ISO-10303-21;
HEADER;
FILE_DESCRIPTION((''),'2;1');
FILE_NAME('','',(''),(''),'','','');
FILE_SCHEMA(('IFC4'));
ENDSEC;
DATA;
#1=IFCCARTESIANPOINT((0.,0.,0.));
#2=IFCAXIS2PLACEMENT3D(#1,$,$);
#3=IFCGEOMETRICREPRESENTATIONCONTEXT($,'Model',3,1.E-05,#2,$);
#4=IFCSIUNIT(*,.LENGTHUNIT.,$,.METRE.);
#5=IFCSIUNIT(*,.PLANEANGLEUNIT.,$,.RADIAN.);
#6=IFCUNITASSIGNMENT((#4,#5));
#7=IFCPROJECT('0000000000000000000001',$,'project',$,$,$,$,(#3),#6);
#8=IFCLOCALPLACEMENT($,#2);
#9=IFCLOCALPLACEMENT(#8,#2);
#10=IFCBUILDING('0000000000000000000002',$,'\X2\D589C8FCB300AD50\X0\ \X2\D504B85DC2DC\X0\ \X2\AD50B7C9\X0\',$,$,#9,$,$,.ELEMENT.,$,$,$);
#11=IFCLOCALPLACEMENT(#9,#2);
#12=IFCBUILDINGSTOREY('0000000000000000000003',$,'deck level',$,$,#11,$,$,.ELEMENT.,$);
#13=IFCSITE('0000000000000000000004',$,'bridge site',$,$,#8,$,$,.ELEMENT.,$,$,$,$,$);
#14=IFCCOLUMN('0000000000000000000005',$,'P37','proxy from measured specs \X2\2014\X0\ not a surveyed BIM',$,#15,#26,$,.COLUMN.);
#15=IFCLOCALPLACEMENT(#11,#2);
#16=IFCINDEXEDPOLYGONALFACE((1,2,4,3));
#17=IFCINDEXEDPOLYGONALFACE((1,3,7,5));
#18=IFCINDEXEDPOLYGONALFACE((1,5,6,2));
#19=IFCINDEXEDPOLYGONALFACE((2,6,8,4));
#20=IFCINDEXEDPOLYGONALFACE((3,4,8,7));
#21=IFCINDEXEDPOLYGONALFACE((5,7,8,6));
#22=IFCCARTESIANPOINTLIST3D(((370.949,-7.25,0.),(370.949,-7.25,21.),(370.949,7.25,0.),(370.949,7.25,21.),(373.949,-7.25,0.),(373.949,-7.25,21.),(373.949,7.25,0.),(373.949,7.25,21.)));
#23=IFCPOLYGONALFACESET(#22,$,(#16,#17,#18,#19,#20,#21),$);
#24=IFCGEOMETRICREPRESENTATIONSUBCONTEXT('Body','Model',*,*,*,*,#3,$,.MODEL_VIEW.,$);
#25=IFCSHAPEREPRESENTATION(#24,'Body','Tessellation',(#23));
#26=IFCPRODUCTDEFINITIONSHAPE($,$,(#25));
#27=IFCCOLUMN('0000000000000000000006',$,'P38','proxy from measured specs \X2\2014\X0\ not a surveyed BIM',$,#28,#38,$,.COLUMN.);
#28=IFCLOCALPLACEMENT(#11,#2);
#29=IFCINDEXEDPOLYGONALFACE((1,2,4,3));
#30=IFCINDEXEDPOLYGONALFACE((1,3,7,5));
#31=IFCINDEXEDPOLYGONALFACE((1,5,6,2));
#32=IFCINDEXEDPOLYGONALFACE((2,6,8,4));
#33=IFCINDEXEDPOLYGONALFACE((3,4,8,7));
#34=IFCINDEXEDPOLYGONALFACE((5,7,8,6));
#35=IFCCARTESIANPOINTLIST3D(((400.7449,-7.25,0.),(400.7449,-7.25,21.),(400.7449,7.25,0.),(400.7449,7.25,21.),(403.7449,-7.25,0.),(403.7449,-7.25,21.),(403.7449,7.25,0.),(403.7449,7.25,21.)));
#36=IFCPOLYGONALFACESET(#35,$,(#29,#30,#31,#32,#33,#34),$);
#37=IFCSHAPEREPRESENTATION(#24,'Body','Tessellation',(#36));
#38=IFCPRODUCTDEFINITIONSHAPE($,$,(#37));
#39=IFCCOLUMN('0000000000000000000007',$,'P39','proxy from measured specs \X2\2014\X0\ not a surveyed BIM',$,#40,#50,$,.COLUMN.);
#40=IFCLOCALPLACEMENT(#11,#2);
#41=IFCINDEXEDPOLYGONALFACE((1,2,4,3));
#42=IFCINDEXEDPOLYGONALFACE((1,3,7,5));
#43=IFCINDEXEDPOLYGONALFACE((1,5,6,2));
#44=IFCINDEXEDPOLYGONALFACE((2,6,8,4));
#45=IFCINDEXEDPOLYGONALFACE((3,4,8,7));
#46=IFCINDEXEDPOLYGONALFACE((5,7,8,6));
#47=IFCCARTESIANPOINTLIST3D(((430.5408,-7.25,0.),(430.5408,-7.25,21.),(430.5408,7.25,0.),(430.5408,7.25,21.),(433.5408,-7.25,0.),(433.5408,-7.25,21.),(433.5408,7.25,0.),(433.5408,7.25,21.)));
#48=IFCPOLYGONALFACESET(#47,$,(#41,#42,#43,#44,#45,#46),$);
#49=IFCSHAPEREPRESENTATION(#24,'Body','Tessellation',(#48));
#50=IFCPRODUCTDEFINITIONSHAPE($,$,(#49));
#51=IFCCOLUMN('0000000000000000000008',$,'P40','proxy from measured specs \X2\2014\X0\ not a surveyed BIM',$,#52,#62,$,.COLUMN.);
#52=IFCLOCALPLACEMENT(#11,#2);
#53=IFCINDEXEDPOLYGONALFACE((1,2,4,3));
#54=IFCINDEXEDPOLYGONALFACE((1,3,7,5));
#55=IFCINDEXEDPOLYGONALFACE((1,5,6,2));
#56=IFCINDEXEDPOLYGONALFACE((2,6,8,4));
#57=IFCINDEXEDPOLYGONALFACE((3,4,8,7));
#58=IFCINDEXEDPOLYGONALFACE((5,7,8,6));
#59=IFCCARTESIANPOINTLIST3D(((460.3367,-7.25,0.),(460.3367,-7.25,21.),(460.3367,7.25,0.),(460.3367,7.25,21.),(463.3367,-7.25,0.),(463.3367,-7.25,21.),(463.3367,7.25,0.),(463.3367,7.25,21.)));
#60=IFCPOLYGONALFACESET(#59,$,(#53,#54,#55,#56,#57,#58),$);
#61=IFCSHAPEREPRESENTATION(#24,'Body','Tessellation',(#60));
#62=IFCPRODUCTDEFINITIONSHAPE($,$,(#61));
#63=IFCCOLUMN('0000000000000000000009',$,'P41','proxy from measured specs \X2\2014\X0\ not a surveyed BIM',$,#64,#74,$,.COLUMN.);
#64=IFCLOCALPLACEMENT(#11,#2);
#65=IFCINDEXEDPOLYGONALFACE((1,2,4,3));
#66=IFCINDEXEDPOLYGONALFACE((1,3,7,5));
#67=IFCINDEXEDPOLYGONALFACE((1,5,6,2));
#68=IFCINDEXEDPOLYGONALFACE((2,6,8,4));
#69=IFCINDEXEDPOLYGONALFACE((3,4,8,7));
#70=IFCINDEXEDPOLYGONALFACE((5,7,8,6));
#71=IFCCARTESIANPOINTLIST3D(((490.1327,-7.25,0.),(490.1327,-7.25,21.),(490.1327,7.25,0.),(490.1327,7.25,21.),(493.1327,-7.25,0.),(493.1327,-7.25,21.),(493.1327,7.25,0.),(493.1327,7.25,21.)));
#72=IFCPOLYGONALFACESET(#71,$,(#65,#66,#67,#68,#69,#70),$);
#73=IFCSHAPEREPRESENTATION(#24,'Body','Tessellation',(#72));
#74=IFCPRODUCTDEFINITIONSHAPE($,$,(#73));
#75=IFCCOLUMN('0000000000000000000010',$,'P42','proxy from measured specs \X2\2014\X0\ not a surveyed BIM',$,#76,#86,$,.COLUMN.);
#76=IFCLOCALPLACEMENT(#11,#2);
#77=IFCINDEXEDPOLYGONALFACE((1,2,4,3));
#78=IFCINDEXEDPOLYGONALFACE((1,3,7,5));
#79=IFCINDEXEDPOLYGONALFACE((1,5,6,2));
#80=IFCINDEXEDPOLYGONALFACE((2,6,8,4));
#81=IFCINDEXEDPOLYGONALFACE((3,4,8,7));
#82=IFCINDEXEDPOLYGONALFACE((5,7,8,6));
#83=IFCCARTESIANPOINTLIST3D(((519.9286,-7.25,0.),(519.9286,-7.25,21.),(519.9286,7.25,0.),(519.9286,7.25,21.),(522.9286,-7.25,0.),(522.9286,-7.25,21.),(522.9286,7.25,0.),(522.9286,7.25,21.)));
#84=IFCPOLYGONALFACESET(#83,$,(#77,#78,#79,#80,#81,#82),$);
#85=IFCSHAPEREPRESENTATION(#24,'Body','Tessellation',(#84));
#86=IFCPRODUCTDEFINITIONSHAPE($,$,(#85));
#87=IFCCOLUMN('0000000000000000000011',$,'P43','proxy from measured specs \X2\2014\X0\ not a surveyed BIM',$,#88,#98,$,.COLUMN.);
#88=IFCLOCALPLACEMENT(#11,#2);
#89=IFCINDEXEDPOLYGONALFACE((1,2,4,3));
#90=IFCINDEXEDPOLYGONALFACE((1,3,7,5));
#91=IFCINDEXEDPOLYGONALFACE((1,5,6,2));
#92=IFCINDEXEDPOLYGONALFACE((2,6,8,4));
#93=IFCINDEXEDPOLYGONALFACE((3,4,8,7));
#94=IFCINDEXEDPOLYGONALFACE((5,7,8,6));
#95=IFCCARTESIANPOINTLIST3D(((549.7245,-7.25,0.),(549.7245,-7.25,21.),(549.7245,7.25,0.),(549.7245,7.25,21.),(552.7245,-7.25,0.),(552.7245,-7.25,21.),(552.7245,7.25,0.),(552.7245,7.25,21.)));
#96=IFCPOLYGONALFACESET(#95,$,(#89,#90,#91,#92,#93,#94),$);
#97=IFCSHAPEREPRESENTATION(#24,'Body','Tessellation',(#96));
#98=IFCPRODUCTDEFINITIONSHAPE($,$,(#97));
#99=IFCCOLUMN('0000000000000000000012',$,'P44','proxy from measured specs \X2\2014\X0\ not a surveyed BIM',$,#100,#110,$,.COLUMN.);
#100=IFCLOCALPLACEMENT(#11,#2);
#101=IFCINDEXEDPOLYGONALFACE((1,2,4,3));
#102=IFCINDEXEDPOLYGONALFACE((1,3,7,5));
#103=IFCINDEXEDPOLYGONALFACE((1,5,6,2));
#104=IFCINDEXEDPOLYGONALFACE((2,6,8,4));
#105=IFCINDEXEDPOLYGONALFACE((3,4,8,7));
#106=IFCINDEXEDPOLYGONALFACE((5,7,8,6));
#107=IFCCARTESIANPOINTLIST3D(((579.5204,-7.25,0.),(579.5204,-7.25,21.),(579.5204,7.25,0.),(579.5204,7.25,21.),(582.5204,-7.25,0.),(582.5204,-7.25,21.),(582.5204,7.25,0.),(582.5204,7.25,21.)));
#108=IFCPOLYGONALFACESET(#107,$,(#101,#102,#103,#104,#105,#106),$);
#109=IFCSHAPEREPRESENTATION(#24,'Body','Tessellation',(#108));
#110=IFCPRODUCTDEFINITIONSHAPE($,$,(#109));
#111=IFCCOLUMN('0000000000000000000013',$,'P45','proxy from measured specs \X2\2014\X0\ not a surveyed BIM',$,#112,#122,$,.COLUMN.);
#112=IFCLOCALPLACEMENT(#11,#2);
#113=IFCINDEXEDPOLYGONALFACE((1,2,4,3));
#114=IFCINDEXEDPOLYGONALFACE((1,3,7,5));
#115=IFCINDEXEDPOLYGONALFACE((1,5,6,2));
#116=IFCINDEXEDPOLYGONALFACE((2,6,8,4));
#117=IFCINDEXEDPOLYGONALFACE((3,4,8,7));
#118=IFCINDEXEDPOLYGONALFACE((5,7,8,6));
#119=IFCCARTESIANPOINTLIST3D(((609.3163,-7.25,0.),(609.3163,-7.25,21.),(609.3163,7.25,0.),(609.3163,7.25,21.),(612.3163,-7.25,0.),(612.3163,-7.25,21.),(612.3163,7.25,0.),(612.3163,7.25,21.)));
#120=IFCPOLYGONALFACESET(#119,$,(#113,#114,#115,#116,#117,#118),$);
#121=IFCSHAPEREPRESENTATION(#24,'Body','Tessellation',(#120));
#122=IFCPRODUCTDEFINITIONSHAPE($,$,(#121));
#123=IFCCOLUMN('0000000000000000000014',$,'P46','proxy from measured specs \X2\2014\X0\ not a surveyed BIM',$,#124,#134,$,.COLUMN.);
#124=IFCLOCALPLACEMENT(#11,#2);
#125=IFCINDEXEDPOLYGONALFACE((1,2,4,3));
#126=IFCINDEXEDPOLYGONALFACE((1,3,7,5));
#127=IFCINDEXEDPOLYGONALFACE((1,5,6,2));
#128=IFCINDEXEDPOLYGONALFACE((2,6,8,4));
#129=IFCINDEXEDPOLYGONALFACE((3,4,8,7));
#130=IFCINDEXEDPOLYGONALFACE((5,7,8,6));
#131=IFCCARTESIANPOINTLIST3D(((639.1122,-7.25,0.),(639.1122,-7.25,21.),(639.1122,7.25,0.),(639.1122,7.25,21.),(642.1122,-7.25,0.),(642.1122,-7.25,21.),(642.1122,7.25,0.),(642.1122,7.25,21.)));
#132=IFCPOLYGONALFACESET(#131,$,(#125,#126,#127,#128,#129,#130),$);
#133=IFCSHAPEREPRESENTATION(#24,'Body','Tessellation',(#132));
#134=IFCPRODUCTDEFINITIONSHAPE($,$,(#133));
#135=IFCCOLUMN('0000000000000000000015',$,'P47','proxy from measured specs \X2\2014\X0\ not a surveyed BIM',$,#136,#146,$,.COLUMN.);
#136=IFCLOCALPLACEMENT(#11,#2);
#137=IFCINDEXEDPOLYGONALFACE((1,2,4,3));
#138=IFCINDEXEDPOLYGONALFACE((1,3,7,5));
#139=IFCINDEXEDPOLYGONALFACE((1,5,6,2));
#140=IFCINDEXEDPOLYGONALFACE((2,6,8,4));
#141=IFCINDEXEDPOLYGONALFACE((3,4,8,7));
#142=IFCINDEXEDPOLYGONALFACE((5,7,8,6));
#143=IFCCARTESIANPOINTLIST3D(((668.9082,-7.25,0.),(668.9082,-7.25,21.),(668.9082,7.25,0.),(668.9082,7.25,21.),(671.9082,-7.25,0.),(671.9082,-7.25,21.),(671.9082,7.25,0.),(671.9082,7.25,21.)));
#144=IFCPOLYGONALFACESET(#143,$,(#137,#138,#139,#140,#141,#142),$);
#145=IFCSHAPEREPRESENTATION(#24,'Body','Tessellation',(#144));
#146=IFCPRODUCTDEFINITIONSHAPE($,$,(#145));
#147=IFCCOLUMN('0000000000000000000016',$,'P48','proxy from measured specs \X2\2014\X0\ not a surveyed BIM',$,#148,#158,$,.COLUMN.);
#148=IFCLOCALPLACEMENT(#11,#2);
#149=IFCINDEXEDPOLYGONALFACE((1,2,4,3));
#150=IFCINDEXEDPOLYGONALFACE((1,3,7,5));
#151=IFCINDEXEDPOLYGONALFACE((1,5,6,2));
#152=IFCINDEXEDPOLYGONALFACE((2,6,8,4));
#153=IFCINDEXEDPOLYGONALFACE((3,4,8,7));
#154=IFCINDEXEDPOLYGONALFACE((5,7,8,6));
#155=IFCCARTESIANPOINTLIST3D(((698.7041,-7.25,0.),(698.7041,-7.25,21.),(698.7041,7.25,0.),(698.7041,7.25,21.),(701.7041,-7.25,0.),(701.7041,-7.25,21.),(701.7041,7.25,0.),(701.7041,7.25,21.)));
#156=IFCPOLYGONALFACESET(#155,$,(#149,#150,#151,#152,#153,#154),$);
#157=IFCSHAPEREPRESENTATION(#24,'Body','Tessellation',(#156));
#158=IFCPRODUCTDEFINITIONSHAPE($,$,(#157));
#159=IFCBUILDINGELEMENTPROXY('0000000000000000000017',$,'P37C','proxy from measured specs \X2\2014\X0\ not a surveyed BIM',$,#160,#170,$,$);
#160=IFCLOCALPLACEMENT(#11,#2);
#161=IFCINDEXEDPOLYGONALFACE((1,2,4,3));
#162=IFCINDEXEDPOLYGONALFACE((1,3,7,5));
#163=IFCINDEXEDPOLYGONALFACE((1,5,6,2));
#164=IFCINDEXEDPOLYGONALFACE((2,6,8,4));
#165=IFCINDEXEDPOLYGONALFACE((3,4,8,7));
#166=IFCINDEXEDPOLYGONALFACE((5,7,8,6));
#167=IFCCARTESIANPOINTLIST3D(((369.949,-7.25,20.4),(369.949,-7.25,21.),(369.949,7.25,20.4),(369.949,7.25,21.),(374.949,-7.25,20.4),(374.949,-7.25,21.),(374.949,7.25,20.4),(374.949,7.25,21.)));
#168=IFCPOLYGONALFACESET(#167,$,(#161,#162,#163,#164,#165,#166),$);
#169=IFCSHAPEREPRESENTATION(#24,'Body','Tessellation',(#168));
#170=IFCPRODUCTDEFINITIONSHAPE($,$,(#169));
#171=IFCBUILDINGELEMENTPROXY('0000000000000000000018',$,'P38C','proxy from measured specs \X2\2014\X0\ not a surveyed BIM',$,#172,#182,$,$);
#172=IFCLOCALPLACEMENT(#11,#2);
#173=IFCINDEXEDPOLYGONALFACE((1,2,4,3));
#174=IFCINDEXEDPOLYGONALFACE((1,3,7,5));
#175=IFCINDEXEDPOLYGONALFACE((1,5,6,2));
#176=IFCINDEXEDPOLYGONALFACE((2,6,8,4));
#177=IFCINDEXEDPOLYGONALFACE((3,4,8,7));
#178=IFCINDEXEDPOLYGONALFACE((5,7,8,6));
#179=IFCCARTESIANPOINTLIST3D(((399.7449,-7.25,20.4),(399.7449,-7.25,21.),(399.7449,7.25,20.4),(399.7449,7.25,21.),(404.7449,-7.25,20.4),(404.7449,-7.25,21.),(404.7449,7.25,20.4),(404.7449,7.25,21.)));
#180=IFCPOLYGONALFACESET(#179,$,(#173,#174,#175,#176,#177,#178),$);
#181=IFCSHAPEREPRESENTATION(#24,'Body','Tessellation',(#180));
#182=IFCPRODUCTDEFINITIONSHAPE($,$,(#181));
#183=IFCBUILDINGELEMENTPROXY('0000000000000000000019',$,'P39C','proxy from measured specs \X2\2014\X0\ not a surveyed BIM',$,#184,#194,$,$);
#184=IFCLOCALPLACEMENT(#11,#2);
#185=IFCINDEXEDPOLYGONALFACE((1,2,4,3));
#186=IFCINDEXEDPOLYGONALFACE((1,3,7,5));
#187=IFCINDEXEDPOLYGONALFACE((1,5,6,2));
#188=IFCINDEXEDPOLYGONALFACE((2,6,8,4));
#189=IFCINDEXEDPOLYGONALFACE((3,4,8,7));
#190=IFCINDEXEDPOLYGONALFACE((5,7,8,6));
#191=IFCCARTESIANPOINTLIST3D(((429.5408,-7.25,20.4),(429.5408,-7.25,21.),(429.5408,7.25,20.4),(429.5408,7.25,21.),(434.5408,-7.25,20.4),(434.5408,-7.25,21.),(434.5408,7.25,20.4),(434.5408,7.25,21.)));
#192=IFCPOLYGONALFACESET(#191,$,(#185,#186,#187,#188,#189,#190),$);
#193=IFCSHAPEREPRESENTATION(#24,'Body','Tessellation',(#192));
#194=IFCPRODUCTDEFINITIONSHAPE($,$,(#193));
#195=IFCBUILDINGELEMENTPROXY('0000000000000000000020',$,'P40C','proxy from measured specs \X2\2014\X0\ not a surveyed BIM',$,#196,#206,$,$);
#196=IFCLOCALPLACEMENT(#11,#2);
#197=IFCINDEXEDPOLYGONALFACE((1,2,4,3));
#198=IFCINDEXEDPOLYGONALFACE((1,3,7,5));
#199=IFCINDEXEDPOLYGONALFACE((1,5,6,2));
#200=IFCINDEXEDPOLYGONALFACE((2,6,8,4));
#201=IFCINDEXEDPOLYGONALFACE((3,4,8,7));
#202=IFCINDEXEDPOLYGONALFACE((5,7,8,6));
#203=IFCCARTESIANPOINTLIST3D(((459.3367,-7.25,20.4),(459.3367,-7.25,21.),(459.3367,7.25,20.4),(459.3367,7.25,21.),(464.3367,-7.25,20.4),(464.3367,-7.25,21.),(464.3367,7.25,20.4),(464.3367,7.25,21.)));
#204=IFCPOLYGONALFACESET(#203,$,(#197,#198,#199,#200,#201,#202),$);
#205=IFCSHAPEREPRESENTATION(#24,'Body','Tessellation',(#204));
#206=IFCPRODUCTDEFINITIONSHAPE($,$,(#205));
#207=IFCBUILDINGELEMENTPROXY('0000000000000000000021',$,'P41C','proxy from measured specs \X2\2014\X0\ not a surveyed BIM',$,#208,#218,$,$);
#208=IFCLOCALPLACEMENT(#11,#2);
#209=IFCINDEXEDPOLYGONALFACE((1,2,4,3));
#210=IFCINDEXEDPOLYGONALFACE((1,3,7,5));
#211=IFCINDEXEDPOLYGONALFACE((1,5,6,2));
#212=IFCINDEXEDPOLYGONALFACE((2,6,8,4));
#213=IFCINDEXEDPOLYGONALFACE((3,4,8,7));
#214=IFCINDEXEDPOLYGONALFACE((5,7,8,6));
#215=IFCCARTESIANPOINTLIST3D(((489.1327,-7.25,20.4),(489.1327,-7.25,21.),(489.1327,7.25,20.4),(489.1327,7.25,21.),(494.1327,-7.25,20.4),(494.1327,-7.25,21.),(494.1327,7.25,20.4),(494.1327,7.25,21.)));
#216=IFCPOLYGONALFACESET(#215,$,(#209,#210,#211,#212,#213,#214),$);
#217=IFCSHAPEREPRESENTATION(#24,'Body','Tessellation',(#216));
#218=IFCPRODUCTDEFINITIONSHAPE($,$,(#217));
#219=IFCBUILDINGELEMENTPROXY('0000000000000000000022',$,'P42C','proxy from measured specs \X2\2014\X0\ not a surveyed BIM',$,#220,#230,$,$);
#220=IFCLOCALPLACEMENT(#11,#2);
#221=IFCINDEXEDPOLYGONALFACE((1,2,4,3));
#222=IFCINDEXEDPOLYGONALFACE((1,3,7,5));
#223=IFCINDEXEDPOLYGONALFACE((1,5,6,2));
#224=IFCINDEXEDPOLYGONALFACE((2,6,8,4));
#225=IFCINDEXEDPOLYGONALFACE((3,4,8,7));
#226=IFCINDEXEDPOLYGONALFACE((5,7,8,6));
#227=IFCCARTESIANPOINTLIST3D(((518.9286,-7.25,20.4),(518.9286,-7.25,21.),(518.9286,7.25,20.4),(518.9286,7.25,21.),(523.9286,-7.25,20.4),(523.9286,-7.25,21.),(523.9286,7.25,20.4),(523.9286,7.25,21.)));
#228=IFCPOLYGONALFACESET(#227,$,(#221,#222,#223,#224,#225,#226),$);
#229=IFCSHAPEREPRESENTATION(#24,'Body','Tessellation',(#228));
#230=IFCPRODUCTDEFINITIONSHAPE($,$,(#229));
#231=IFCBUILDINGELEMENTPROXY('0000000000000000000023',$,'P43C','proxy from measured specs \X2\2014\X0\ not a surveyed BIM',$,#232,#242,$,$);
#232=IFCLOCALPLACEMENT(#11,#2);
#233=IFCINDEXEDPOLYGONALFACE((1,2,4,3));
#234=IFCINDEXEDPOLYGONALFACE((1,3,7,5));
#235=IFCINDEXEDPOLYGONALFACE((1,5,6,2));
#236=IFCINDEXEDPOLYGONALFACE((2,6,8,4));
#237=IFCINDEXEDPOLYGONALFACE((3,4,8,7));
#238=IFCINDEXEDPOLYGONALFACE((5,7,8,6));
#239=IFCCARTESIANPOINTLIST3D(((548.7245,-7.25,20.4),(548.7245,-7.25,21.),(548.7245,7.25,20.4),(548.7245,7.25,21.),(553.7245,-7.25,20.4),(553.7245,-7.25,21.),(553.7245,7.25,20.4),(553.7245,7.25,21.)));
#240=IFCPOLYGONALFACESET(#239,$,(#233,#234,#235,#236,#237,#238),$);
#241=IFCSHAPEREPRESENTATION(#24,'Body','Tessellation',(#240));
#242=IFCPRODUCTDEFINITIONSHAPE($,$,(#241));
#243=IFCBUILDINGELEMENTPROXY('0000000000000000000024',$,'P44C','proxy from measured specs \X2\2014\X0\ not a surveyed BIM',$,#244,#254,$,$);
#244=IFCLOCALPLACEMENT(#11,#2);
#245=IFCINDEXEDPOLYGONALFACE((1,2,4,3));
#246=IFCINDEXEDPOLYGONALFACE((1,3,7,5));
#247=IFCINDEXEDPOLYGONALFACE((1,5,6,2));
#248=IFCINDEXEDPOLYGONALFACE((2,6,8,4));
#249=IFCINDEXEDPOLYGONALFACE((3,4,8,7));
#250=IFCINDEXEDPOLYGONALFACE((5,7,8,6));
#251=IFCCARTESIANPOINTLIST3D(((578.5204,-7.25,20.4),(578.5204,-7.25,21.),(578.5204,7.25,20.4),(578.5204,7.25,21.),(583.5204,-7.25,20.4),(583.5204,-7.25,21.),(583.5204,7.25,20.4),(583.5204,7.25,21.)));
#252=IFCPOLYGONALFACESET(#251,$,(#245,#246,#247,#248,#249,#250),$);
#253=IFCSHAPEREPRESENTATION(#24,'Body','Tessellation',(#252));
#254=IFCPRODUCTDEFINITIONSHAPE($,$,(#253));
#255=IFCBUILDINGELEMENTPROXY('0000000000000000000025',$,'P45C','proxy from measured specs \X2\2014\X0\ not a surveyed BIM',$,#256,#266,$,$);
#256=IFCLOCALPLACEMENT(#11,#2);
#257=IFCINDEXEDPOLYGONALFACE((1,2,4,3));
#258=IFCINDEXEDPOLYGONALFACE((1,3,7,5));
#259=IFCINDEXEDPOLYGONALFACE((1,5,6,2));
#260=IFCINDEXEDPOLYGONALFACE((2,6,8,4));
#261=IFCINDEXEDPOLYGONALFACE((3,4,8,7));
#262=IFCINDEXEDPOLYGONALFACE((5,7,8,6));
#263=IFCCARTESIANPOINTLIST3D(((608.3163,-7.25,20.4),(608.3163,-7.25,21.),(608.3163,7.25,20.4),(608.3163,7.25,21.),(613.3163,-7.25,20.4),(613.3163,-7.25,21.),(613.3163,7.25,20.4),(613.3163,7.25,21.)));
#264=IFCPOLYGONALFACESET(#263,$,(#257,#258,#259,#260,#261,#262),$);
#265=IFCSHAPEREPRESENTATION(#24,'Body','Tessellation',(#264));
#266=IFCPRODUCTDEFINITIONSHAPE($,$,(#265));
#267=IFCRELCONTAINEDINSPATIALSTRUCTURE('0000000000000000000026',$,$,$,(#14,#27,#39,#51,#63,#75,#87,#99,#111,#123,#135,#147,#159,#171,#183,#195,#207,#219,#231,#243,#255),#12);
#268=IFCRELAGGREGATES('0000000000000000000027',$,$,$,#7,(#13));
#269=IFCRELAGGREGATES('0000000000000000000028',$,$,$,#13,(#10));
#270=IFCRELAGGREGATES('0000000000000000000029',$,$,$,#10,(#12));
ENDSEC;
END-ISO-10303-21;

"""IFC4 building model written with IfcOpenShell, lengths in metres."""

from ifc_helpers import new_model, si_unit, frame, origin, origin_2d, place, context, subcontext, project, spatial, rectangle, extrude, element, save


model = new_model("IFC4")

# Units and contexts
model_context = context("Model", 3, precision=1e-05, world=origin())
body_context = subcontext(model_context, "Body", "Model", "MODEL_VIEW")
ifc_project = project(units=[si_unit("LENGTHUNIT", "METRE"), si_unit("PLANEANGLEUNIT", "RADIAN")], contexts=[model_context])

# Site, building, storey
site_placement = place(None, origin())
site = spatial("IfcSite", under=ifc_project, at=site_placement, Name="bridge site", CompositionType="ELEMENT")
building_placement = place(site_placement, origin())
building = spatial("IfcBuilding", under=site, at=building_placement, Name="행주대교 프록시 교량", CompositionType="ELEMENT")
storey_placement = place(building_placement, origin())
storey = spatial("IfcBuildingStorey", under=building, at=storey_placement, Name="deck level", CompositionType="ELEMENT")

# Columns
for number, where, name in (
    (1, (372.449, 0.0, 0.0), "P37"),
    (2, (402.2449, 0.0, 0.0), "P38"),
    (3, (432.0408, 0.0, 0.0), "P39"),
    (4, (461.8367, 0.0, 0.0), "P40"),
    (5, (491.6327, 0.0, 0.0), "P41"),
    (6, (521.4286, 0.0, 0.0), "P42"),
    (7, (551.2245, 0.0, 0.0), "P43"),
    (8, (581.0204, 0.0, 0.0), "P44"),
    (9, (610.8163, 0.0, 0.0), "P45"),
    (10, (640.6122, 0.0, 0.0), "P46"),
    (11, (670.4082, 0.0, 0.0), "P47"),
    (12, (700.2041, 0.0, 0.0), "P48"),
):
    element("IfcColumn", number, at=place(storey_placement, frame(where)), inside=storey, Name=name, Description="proxy from measured specs — not a surveyed BIM", PredefinedType="COLUMN", context=body_context, shape_type="SweptSolid", body=[
        extrude(rectangle(XDim=3.0, YDim=14.5, at=origin_2d()), origin(), (0.0, 0.0, 1.0), 21.0),
    ])

# Building element proxies
for number, where, name in (
    (13, (372.449, 0.0, 20.4), "P37C"),
    (14, (402.2449, 0.0, 20.4), "P38C"),
    (15, (432.0408, 0.0, 20.4), "P39C"),
    (16, (461.8367, 0.0, 20.4), "P40C"),
    (17, (491.6327, 0.0, 20.4), "P41C"),
    (18, (521.4286, 0.0, 20.4), "P42C"),
    (19, (551.2245, 0.0, 20.4), "P43C"),
    (20, (581.0204, 0.0, 20.4), "P44C"),
    (21, (610.8163, 0.0, 20.4), "P45C"),
):
    element("IfcBuildingElementProxy", number, at=place(storey_placement, frame(where)), inside=storey, Name=name, Description="proxy from measured specs — not a surveyed BIM", context=body_context, shape_type="SweptSolid", body=[
        extrude(rectangle(XDim=5.0, YDim=14.5, at=origin_2d()), origin(), (0.0, 0.0, 1.0), 0.6),
    ])

save(model, "model.ifc")
